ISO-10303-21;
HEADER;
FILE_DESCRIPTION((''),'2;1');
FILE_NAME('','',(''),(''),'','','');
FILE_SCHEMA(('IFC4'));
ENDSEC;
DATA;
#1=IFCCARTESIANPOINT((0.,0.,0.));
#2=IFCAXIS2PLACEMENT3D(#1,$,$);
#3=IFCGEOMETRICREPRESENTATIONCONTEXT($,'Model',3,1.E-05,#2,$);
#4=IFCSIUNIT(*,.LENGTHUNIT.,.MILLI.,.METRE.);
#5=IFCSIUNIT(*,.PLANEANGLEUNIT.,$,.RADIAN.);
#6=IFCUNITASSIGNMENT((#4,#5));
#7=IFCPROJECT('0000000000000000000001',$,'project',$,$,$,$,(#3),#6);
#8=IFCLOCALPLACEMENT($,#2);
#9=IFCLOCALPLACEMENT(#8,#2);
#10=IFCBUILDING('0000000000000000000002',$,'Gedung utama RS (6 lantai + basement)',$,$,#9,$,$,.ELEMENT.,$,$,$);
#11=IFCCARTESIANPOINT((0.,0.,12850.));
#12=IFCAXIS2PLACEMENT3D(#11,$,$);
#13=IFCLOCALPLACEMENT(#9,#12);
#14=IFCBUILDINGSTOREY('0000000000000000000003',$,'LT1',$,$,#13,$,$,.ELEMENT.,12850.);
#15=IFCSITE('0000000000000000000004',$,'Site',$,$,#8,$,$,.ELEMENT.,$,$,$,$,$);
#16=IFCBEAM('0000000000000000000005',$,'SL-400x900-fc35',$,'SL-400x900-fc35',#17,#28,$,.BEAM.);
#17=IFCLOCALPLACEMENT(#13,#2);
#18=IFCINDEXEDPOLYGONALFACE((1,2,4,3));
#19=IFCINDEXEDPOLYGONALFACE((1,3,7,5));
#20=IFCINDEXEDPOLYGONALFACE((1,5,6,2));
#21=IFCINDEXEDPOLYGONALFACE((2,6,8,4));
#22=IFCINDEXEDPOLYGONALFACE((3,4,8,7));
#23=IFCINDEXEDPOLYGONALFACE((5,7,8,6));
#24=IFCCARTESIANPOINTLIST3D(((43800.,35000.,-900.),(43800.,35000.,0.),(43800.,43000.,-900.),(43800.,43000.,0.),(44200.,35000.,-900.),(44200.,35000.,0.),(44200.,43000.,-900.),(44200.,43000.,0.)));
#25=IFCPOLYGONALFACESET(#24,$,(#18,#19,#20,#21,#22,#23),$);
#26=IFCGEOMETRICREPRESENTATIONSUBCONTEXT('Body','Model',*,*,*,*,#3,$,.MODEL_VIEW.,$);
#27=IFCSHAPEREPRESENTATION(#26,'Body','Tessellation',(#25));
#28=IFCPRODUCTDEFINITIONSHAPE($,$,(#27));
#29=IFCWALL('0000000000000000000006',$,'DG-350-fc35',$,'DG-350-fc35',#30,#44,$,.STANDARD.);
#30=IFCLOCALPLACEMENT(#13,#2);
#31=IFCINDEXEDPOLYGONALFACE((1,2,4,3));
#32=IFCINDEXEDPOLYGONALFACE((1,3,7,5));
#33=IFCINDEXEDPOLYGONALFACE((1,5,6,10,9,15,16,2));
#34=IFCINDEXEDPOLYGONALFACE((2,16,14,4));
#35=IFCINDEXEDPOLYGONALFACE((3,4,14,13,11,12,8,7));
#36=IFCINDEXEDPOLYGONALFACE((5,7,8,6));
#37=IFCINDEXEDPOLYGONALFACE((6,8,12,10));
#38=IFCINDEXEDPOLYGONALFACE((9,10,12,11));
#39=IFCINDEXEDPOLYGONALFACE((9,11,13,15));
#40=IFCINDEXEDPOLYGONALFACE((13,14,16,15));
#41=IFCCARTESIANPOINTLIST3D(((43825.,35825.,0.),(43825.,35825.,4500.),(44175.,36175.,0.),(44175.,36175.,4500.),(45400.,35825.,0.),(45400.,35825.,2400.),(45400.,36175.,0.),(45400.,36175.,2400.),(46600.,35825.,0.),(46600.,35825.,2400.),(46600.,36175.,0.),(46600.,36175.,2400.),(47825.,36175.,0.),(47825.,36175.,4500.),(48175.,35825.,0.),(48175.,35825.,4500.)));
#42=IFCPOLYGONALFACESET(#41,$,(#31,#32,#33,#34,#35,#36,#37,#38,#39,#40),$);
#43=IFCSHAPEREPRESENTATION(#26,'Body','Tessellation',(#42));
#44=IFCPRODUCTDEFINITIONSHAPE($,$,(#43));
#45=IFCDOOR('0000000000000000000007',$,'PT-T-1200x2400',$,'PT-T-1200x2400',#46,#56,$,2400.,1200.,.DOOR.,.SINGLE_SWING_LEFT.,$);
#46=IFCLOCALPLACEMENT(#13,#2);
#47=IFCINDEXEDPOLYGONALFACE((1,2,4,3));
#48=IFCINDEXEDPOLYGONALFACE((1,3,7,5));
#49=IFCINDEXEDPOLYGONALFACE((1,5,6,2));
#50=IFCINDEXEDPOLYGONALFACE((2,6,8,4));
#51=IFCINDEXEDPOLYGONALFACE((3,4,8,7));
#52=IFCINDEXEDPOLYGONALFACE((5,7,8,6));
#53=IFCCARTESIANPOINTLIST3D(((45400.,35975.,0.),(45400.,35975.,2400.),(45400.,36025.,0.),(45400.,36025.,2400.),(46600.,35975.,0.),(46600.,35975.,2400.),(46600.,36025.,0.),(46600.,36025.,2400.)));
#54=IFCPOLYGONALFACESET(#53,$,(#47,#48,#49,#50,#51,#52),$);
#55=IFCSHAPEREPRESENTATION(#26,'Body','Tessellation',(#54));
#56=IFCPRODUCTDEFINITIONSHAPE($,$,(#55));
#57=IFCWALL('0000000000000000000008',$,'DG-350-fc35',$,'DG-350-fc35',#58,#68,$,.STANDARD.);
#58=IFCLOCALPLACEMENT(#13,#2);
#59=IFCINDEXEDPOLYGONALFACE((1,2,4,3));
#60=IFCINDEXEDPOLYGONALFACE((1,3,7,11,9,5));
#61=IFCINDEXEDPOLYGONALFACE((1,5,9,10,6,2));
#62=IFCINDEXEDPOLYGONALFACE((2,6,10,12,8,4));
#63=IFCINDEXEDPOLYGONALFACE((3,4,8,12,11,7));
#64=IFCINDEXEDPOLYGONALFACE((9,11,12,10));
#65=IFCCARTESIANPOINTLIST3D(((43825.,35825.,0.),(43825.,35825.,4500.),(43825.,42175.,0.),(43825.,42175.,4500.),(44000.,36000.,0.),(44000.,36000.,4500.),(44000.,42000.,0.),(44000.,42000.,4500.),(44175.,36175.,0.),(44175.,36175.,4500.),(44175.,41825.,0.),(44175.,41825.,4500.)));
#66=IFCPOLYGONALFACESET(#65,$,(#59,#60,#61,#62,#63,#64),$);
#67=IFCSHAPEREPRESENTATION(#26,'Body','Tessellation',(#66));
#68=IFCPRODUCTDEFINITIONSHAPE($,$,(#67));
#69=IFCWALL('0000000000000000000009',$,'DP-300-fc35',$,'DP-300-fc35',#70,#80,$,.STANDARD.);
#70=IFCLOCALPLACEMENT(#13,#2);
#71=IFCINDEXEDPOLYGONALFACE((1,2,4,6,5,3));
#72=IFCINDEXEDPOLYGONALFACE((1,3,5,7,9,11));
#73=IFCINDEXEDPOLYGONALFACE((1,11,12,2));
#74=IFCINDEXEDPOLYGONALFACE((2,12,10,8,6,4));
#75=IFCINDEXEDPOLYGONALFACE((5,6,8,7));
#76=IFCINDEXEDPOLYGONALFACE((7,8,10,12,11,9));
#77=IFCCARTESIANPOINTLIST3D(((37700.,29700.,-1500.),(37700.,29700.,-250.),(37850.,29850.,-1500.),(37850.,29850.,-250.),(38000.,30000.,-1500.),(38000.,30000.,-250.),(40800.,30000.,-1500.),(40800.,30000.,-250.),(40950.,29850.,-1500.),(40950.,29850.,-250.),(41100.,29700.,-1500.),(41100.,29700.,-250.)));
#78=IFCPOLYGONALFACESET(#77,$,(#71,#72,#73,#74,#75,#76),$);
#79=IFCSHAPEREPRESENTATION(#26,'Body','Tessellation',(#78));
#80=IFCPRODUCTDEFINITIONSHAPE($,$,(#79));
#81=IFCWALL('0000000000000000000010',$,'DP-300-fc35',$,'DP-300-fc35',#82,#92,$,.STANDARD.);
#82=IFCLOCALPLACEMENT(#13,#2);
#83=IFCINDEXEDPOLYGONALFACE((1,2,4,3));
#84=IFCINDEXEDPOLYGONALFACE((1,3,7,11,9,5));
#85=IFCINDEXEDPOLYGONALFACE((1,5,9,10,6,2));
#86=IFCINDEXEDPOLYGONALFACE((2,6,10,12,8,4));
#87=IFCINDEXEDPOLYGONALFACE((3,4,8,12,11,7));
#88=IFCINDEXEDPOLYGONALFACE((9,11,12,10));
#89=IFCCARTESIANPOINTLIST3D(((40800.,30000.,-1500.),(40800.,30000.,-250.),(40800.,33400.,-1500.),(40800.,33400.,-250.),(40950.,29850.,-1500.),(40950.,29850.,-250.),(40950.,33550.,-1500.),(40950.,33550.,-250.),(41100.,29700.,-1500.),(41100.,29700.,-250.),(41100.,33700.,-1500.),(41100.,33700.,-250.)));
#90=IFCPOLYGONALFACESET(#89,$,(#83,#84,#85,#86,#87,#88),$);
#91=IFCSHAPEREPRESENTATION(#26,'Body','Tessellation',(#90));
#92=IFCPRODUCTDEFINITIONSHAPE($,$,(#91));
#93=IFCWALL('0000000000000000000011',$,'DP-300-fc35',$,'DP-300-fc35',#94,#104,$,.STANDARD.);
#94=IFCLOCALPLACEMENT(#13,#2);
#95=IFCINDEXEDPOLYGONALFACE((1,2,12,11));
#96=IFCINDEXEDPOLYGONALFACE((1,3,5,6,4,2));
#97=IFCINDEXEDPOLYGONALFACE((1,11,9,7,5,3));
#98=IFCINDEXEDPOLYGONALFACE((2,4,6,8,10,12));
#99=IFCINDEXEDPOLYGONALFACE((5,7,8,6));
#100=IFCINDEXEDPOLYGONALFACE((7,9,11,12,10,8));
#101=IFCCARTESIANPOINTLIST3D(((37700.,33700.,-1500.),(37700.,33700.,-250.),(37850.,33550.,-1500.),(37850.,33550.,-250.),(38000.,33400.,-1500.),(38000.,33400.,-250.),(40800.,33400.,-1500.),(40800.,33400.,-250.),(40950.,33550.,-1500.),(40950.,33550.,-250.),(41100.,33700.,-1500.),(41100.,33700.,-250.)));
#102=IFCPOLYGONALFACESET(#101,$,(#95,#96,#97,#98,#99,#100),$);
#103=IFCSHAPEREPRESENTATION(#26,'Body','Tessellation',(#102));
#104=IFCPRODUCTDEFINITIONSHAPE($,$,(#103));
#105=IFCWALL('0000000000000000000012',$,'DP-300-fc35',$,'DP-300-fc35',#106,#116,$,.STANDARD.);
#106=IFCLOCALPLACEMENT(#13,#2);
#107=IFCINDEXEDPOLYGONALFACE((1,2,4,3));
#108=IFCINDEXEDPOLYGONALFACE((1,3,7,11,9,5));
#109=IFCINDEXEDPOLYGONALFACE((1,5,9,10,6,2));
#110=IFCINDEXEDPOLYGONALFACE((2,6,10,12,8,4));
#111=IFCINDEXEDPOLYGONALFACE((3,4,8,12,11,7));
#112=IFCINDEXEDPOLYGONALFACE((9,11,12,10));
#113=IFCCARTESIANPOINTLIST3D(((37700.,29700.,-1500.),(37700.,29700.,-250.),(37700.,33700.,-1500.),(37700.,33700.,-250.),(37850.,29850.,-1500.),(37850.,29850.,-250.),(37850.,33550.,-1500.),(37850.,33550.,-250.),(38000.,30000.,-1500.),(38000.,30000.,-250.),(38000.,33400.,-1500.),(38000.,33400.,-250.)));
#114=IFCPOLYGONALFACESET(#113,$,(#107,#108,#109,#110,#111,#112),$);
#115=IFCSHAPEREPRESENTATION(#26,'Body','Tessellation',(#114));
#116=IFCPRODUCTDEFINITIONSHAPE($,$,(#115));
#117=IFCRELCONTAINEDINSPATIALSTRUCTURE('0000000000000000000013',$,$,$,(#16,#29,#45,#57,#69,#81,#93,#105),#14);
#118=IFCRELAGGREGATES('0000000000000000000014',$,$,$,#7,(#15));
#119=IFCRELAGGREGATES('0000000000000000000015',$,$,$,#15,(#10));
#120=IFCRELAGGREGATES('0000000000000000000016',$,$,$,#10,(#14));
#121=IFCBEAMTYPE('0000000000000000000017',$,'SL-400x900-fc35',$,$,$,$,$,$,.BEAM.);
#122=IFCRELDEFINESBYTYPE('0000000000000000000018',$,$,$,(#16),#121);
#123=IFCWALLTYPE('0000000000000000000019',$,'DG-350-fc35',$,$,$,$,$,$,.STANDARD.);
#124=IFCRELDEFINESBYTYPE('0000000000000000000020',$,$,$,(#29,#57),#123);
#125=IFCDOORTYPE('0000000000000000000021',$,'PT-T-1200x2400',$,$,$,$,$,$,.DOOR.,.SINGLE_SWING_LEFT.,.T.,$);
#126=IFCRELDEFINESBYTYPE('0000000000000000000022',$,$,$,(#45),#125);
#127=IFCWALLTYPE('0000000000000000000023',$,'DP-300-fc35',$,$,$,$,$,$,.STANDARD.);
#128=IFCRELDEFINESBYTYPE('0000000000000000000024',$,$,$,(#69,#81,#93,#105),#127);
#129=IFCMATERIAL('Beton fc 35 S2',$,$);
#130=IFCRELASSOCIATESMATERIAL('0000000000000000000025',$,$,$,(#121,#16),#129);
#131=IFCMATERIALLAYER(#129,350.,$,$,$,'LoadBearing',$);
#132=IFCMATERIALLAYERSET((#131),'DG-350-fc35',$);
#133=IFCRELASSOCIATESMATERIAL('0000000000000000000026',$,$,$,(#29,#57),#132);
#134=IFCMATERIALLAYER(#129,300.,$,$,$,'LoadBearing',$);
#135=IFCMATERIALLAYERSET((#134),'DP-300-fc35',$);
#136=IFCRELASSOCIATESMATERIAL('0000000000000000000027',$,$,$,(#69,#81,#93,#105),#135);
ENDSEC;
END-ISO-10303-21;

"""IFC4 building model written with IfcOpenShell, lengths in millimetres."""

from ifc_helpers import new_model, si_unit, frame, frame_2d, origin, origin_2d, place, context, subcontext, project, spatial, polyline, rectangle, outline, extrude, material, layer, layer_set, layer_usage, material_profile, profile_set, profile_usage, type_object, element, fill, save


model = new_model("IFC4")

# Units and contexts
model_context = context("Model", 3, precision=1e-05, world=origin())
body_context = subcontext(model_context, "Body", "Model", "MODEL_VIEW")
ifc_project = project(units=[si_unit("LENGTHUNIT", "METRE", prefix="MILLI"), si_unit("PLANEANGLEUNIT", "RADIAN")], contexts=[model_context])

# Site, building, storey
site_placement = place(None, origin())
site = spatial("IfcSite", under=ifc_project, at=site_placement, Name="Site", CompositionType="ELEMENT")
building_placement = place(site_placement, origin())
building = spatial("IfcBuilding", under=site, at=building_placement, Name="Gedung utama RS (6 lantai + basement)", CompositionType="ELEMENT")
storey_placement = place(building_placement, frame((0.0, 0.0, 12850.0)))
storey = spatial("IfcBuildingStorey", under=building, at=storey_placement, Name="LT1", CompositionType="ELEMENT", Elevation=12850.0)

# Beam
ifc_material = material(Name="Beton fc 35 S2")
ifc_material_profile_1 = material_profile(ifc_material, rectangle(XDim=400.0, YDim=900.0, at=origin_2d()), Name="SL-400x900-fc35")
ifc_profile_set_1 = profile_set([ifc_material_profile_1], Name="SL-400x900-fc35")
ifc_profile_usage_1 = profile_usage(ifc_profile_set_1, cardinal=8)
beam_type_1 = type_object("IfcBeamType", Name="SL-400x900-fc35", PredefinedType="BEAM", material=ifc_profile_set_1)
beam_1_placement = place(storey_placement, frame((44000.0, 35000.0, -450.0)))
element("IfcBeam", 1, at=beam_1_placement, inside=storey, type_object=beam_type_1, material=ifc_profile_usage_1, Name="SL-400x900-fc35", ObjectType="SL-400x900-fc35", PredefinedType="BEAM", context=body_context, shape_type="SweptSolid", body=[
    extrude(rectangle(XDim=400.0, YDim=900.0, at=origin_2d()), frame((0.0, 0.0, 0.0), z_axis=(0.0, 1.0, 0.0), x_axis=(-1.0, 0.0, 0.0)), (0.0, 0.0, 1.0), 8000.0),
])

# Wall, opening, door
ifc_layer_1 = layer(ifc_material, 350.0, Category="LoadBearing")
ifc_layer_set_1 = layer_set([ifc_layer_1], Name="DG-350-fc35")
ifc_layer_usage_1 = layer_usage(ifc_layer_set_1, "AXIS2", "NEGATIVE", 175.0)
wall_type_1 = type_object("IfcWallType", Name="DG-350-fc35", PredefinedType="STANDARD")
wall_1_placement = place(storey_placement, frame((44000.0, 36000.0, 0.0), z_axis=(0.0, 0.0, 1.0), x_axis=(1.0, 0.0, 0.0)))
wall_1 = element("IfcWall", 2, at=wall_1_placement, inside=storey, type_object=wall_type_1, material=ifc_layer_usage_1, Name="DG-350-fc35", ObjectType="DG-350-fc35", PredefinedType="STANDARD", context=body_context, shape_type="SweptSolid", body=[
    extrude(outline(polyline([(-175.0, -175.0), (0.0, 0.0), (175.0, 175.0), (3825.0, 175.0), (4000.0, 0.0), (4175.0, -175.0), (-175.0, -175.0)])), origin(), (0.0, 0.0, 1.0), 4500.0),
])
opening_placement = place(wall_1_placement, frame((1400.0, 0.0, 0.0), z_axis=(0.0, 0.0, 1.0), x_axis=(1.0, 0.0, 0.0)))
opening = element("IfcOpeningElement", 3, at=opening_placement, cuts=wall_1, PredefinedType="OPENING", context=body_context, shape_type="SweptSolid", body=[
    extrude(rectangle(XDim=1200.0, YDim=370.0, at=frame_2d((600.0, 0.0))), origin(), (0.0, 0.0, 1.0), 2400.0),
])
door_type = type_object("IfcDoorType", Name="PT-T-1200x2400", OperationType="SINGLE_SWING_LEFT", ParameterTakesPrecedence=True, PredefinedType="DOOR")
door_placement = place(opening_placement, origin())
door = element("IfcDoor", 4, at=door_placement, inside=storey, type_object=door_type, Name="PT-T-1200x2400", ObjectType="PT-T-1200x2400", OperationType="SINGLE_SWING_LEFT", OverallHeight=2400.0, OverallWidth=1200.0, PredefinedType="DOOR", context=body_context, shape_type="SweptSolid", body=[
    extrude(rectangle(XDim=1200.0, YDim=50.0, at=frame_2d((600.0, 0.0))), origin(), (0.0, 0.0, 1.0), 2400.0),
])
fill(opening, door)

# Walls
wall_2_placement = place(storey_placement, frame((44000.0, 42000.0, 0.0), z_axis=(0.0, 0.0, 1.0), x_axis=(0.0, -1.0, 0.0)))
element("IfcWall", 5, at=wall_2_placement, inside=storey, type_object=wall_type_1, material=ifc_layer_usage_1, Name="DG-350-fc35", ObjectType="DG-350-fc35", PredefinedType="STANDARD", context=body_context, shape_type="SweptSolid", body=[
    extrude(outline(polyline([(-175.0, -175.0), (0.0, 0.0), (175.0, 175.0), (5825.0, 175.0), (6000.0, 0.0), (6175.0, -175.0), (-175.0, -175.0)])), origin(), (0.0, 0.0, 1.0), 4500.0),
])
ifc_layer_2 = layer(ifc_material, 300.0, Category="LoadBearing")
ifc_layer_set_2 = layer_set([ifc_layer_2], Name="DP-300-fc35")
ifc_layer_usage_2 = layer_usage(ifc_layer_set_2, "AXIS2", "NEGATIVE", 150.0)
wall_type_2 = type_object("IfcWallType", Name="DP-300-fc35", PredefinedType="STANDARD")
wall_3_placement = place(storey_placement, frame((37850.0, 29850.0, -1500.0), z_axis=(0.0, 0.0, 1.0), x_axis=(1.0, 0.0, 0.0)))
element("IfcWall", 6, at=wall_3_placement, inside=storey, type_object=wall_type_2, material=ifc_layer_usage_2, Name="DP-300-fc35", ObjectType="DP-300-fc35", PredefinedType="STANDARD", context=body_context, shape_type="SweptSolid", body=[
    extrude(outline(polyline([(-150.0, -150.0), (0.0, 0.0), (150.0, 150.0), (2950.0, 150.0), (3100.0, 0.0), (3250.0, -150.0), (-150.0, -150.0)])), origin(), (0.0, 0.0, 1.0), 1250.0),
])
wall_4_placement = place(storey_placement, frame((40950.0, 29850.0, -1500.0), z_axis=(0.0, 0.0, 1.0), x_axis=(0.0, 1.0, 0.0)))
element("IfcWall", 7, at=wall_4_placement, inside=storey, type_object=wall_type_2, material=ifc_layer_usage_2, Name="DP-300-fc35", ObjectType="DP-300-fc35", PredefinedType="STANDARD", context=body_context, shape_type="SweptSolid", body=[
    extrude(outline(polyline([(-150.0, -150.0), (0.0, 0.0), (150.0, 150.0), (3550.0, 150.0), (3700.0, 0.0), (3850.0, -150.0), (-150.0, -150.0)])), origin(), (0.0, 0.0, 1.0), 1250.0),
])
wall_5_placement = place(storey_placement, frame((40950.0, 33550.0, -1500.0), z_axis=(0.0, 0.0, 1.0), x_axis=(-1.0, 0.0, 0.0)))
element("IfcWall", 8, at=wall_5_placement, inside=storey, type_object=wall_type_2, material=ifc_layer_usage_2, Name="DP-300-fc35", ObjectType="DP-300-fc35", PredefinedType="STANDARD", context=body_context, shape_type="SweptSolid", body=[
    extrude(outline(polyline([(-150.0, -150.0), (0.0, 0.0), (150.0, 150.0), (2950.0, 150.0), (3100.0, 0.0), (3250.0, -150.0), (-150.0, -150.0)])), origin(), (0.0, 0.0, 1.0), 1250.0),
])
wall_6_placement = place(storey_placement, frame((37850.0, 33550.0, -1500.0), z_axis=(0.0, 0.0, 1.0), x_axis=(0.0, -1.0, 0.0)))
element("IfcWall", 9, at=wall_6_placement, inside=storey, type_object=wall_type_2, material=ifc_layer_usage_2, Name="DP-300-fc35", ObjectType="DP-300-fc35", PredefinedType="STANDARD", context=body_context, shape_type="SweptSolid", body=[
    extrude(outline(polyline([(-150.0, -150.0), (0.0, 0.0), (150.0, 150.0), (3550.0, 150.0), (3700.0, 0.0), (3850.0, -150.0), (-150.0, -150.0)])), origin(), (0.0, 0.0, 1.0), 1250.0),
])

save(model, "model.ifc")
